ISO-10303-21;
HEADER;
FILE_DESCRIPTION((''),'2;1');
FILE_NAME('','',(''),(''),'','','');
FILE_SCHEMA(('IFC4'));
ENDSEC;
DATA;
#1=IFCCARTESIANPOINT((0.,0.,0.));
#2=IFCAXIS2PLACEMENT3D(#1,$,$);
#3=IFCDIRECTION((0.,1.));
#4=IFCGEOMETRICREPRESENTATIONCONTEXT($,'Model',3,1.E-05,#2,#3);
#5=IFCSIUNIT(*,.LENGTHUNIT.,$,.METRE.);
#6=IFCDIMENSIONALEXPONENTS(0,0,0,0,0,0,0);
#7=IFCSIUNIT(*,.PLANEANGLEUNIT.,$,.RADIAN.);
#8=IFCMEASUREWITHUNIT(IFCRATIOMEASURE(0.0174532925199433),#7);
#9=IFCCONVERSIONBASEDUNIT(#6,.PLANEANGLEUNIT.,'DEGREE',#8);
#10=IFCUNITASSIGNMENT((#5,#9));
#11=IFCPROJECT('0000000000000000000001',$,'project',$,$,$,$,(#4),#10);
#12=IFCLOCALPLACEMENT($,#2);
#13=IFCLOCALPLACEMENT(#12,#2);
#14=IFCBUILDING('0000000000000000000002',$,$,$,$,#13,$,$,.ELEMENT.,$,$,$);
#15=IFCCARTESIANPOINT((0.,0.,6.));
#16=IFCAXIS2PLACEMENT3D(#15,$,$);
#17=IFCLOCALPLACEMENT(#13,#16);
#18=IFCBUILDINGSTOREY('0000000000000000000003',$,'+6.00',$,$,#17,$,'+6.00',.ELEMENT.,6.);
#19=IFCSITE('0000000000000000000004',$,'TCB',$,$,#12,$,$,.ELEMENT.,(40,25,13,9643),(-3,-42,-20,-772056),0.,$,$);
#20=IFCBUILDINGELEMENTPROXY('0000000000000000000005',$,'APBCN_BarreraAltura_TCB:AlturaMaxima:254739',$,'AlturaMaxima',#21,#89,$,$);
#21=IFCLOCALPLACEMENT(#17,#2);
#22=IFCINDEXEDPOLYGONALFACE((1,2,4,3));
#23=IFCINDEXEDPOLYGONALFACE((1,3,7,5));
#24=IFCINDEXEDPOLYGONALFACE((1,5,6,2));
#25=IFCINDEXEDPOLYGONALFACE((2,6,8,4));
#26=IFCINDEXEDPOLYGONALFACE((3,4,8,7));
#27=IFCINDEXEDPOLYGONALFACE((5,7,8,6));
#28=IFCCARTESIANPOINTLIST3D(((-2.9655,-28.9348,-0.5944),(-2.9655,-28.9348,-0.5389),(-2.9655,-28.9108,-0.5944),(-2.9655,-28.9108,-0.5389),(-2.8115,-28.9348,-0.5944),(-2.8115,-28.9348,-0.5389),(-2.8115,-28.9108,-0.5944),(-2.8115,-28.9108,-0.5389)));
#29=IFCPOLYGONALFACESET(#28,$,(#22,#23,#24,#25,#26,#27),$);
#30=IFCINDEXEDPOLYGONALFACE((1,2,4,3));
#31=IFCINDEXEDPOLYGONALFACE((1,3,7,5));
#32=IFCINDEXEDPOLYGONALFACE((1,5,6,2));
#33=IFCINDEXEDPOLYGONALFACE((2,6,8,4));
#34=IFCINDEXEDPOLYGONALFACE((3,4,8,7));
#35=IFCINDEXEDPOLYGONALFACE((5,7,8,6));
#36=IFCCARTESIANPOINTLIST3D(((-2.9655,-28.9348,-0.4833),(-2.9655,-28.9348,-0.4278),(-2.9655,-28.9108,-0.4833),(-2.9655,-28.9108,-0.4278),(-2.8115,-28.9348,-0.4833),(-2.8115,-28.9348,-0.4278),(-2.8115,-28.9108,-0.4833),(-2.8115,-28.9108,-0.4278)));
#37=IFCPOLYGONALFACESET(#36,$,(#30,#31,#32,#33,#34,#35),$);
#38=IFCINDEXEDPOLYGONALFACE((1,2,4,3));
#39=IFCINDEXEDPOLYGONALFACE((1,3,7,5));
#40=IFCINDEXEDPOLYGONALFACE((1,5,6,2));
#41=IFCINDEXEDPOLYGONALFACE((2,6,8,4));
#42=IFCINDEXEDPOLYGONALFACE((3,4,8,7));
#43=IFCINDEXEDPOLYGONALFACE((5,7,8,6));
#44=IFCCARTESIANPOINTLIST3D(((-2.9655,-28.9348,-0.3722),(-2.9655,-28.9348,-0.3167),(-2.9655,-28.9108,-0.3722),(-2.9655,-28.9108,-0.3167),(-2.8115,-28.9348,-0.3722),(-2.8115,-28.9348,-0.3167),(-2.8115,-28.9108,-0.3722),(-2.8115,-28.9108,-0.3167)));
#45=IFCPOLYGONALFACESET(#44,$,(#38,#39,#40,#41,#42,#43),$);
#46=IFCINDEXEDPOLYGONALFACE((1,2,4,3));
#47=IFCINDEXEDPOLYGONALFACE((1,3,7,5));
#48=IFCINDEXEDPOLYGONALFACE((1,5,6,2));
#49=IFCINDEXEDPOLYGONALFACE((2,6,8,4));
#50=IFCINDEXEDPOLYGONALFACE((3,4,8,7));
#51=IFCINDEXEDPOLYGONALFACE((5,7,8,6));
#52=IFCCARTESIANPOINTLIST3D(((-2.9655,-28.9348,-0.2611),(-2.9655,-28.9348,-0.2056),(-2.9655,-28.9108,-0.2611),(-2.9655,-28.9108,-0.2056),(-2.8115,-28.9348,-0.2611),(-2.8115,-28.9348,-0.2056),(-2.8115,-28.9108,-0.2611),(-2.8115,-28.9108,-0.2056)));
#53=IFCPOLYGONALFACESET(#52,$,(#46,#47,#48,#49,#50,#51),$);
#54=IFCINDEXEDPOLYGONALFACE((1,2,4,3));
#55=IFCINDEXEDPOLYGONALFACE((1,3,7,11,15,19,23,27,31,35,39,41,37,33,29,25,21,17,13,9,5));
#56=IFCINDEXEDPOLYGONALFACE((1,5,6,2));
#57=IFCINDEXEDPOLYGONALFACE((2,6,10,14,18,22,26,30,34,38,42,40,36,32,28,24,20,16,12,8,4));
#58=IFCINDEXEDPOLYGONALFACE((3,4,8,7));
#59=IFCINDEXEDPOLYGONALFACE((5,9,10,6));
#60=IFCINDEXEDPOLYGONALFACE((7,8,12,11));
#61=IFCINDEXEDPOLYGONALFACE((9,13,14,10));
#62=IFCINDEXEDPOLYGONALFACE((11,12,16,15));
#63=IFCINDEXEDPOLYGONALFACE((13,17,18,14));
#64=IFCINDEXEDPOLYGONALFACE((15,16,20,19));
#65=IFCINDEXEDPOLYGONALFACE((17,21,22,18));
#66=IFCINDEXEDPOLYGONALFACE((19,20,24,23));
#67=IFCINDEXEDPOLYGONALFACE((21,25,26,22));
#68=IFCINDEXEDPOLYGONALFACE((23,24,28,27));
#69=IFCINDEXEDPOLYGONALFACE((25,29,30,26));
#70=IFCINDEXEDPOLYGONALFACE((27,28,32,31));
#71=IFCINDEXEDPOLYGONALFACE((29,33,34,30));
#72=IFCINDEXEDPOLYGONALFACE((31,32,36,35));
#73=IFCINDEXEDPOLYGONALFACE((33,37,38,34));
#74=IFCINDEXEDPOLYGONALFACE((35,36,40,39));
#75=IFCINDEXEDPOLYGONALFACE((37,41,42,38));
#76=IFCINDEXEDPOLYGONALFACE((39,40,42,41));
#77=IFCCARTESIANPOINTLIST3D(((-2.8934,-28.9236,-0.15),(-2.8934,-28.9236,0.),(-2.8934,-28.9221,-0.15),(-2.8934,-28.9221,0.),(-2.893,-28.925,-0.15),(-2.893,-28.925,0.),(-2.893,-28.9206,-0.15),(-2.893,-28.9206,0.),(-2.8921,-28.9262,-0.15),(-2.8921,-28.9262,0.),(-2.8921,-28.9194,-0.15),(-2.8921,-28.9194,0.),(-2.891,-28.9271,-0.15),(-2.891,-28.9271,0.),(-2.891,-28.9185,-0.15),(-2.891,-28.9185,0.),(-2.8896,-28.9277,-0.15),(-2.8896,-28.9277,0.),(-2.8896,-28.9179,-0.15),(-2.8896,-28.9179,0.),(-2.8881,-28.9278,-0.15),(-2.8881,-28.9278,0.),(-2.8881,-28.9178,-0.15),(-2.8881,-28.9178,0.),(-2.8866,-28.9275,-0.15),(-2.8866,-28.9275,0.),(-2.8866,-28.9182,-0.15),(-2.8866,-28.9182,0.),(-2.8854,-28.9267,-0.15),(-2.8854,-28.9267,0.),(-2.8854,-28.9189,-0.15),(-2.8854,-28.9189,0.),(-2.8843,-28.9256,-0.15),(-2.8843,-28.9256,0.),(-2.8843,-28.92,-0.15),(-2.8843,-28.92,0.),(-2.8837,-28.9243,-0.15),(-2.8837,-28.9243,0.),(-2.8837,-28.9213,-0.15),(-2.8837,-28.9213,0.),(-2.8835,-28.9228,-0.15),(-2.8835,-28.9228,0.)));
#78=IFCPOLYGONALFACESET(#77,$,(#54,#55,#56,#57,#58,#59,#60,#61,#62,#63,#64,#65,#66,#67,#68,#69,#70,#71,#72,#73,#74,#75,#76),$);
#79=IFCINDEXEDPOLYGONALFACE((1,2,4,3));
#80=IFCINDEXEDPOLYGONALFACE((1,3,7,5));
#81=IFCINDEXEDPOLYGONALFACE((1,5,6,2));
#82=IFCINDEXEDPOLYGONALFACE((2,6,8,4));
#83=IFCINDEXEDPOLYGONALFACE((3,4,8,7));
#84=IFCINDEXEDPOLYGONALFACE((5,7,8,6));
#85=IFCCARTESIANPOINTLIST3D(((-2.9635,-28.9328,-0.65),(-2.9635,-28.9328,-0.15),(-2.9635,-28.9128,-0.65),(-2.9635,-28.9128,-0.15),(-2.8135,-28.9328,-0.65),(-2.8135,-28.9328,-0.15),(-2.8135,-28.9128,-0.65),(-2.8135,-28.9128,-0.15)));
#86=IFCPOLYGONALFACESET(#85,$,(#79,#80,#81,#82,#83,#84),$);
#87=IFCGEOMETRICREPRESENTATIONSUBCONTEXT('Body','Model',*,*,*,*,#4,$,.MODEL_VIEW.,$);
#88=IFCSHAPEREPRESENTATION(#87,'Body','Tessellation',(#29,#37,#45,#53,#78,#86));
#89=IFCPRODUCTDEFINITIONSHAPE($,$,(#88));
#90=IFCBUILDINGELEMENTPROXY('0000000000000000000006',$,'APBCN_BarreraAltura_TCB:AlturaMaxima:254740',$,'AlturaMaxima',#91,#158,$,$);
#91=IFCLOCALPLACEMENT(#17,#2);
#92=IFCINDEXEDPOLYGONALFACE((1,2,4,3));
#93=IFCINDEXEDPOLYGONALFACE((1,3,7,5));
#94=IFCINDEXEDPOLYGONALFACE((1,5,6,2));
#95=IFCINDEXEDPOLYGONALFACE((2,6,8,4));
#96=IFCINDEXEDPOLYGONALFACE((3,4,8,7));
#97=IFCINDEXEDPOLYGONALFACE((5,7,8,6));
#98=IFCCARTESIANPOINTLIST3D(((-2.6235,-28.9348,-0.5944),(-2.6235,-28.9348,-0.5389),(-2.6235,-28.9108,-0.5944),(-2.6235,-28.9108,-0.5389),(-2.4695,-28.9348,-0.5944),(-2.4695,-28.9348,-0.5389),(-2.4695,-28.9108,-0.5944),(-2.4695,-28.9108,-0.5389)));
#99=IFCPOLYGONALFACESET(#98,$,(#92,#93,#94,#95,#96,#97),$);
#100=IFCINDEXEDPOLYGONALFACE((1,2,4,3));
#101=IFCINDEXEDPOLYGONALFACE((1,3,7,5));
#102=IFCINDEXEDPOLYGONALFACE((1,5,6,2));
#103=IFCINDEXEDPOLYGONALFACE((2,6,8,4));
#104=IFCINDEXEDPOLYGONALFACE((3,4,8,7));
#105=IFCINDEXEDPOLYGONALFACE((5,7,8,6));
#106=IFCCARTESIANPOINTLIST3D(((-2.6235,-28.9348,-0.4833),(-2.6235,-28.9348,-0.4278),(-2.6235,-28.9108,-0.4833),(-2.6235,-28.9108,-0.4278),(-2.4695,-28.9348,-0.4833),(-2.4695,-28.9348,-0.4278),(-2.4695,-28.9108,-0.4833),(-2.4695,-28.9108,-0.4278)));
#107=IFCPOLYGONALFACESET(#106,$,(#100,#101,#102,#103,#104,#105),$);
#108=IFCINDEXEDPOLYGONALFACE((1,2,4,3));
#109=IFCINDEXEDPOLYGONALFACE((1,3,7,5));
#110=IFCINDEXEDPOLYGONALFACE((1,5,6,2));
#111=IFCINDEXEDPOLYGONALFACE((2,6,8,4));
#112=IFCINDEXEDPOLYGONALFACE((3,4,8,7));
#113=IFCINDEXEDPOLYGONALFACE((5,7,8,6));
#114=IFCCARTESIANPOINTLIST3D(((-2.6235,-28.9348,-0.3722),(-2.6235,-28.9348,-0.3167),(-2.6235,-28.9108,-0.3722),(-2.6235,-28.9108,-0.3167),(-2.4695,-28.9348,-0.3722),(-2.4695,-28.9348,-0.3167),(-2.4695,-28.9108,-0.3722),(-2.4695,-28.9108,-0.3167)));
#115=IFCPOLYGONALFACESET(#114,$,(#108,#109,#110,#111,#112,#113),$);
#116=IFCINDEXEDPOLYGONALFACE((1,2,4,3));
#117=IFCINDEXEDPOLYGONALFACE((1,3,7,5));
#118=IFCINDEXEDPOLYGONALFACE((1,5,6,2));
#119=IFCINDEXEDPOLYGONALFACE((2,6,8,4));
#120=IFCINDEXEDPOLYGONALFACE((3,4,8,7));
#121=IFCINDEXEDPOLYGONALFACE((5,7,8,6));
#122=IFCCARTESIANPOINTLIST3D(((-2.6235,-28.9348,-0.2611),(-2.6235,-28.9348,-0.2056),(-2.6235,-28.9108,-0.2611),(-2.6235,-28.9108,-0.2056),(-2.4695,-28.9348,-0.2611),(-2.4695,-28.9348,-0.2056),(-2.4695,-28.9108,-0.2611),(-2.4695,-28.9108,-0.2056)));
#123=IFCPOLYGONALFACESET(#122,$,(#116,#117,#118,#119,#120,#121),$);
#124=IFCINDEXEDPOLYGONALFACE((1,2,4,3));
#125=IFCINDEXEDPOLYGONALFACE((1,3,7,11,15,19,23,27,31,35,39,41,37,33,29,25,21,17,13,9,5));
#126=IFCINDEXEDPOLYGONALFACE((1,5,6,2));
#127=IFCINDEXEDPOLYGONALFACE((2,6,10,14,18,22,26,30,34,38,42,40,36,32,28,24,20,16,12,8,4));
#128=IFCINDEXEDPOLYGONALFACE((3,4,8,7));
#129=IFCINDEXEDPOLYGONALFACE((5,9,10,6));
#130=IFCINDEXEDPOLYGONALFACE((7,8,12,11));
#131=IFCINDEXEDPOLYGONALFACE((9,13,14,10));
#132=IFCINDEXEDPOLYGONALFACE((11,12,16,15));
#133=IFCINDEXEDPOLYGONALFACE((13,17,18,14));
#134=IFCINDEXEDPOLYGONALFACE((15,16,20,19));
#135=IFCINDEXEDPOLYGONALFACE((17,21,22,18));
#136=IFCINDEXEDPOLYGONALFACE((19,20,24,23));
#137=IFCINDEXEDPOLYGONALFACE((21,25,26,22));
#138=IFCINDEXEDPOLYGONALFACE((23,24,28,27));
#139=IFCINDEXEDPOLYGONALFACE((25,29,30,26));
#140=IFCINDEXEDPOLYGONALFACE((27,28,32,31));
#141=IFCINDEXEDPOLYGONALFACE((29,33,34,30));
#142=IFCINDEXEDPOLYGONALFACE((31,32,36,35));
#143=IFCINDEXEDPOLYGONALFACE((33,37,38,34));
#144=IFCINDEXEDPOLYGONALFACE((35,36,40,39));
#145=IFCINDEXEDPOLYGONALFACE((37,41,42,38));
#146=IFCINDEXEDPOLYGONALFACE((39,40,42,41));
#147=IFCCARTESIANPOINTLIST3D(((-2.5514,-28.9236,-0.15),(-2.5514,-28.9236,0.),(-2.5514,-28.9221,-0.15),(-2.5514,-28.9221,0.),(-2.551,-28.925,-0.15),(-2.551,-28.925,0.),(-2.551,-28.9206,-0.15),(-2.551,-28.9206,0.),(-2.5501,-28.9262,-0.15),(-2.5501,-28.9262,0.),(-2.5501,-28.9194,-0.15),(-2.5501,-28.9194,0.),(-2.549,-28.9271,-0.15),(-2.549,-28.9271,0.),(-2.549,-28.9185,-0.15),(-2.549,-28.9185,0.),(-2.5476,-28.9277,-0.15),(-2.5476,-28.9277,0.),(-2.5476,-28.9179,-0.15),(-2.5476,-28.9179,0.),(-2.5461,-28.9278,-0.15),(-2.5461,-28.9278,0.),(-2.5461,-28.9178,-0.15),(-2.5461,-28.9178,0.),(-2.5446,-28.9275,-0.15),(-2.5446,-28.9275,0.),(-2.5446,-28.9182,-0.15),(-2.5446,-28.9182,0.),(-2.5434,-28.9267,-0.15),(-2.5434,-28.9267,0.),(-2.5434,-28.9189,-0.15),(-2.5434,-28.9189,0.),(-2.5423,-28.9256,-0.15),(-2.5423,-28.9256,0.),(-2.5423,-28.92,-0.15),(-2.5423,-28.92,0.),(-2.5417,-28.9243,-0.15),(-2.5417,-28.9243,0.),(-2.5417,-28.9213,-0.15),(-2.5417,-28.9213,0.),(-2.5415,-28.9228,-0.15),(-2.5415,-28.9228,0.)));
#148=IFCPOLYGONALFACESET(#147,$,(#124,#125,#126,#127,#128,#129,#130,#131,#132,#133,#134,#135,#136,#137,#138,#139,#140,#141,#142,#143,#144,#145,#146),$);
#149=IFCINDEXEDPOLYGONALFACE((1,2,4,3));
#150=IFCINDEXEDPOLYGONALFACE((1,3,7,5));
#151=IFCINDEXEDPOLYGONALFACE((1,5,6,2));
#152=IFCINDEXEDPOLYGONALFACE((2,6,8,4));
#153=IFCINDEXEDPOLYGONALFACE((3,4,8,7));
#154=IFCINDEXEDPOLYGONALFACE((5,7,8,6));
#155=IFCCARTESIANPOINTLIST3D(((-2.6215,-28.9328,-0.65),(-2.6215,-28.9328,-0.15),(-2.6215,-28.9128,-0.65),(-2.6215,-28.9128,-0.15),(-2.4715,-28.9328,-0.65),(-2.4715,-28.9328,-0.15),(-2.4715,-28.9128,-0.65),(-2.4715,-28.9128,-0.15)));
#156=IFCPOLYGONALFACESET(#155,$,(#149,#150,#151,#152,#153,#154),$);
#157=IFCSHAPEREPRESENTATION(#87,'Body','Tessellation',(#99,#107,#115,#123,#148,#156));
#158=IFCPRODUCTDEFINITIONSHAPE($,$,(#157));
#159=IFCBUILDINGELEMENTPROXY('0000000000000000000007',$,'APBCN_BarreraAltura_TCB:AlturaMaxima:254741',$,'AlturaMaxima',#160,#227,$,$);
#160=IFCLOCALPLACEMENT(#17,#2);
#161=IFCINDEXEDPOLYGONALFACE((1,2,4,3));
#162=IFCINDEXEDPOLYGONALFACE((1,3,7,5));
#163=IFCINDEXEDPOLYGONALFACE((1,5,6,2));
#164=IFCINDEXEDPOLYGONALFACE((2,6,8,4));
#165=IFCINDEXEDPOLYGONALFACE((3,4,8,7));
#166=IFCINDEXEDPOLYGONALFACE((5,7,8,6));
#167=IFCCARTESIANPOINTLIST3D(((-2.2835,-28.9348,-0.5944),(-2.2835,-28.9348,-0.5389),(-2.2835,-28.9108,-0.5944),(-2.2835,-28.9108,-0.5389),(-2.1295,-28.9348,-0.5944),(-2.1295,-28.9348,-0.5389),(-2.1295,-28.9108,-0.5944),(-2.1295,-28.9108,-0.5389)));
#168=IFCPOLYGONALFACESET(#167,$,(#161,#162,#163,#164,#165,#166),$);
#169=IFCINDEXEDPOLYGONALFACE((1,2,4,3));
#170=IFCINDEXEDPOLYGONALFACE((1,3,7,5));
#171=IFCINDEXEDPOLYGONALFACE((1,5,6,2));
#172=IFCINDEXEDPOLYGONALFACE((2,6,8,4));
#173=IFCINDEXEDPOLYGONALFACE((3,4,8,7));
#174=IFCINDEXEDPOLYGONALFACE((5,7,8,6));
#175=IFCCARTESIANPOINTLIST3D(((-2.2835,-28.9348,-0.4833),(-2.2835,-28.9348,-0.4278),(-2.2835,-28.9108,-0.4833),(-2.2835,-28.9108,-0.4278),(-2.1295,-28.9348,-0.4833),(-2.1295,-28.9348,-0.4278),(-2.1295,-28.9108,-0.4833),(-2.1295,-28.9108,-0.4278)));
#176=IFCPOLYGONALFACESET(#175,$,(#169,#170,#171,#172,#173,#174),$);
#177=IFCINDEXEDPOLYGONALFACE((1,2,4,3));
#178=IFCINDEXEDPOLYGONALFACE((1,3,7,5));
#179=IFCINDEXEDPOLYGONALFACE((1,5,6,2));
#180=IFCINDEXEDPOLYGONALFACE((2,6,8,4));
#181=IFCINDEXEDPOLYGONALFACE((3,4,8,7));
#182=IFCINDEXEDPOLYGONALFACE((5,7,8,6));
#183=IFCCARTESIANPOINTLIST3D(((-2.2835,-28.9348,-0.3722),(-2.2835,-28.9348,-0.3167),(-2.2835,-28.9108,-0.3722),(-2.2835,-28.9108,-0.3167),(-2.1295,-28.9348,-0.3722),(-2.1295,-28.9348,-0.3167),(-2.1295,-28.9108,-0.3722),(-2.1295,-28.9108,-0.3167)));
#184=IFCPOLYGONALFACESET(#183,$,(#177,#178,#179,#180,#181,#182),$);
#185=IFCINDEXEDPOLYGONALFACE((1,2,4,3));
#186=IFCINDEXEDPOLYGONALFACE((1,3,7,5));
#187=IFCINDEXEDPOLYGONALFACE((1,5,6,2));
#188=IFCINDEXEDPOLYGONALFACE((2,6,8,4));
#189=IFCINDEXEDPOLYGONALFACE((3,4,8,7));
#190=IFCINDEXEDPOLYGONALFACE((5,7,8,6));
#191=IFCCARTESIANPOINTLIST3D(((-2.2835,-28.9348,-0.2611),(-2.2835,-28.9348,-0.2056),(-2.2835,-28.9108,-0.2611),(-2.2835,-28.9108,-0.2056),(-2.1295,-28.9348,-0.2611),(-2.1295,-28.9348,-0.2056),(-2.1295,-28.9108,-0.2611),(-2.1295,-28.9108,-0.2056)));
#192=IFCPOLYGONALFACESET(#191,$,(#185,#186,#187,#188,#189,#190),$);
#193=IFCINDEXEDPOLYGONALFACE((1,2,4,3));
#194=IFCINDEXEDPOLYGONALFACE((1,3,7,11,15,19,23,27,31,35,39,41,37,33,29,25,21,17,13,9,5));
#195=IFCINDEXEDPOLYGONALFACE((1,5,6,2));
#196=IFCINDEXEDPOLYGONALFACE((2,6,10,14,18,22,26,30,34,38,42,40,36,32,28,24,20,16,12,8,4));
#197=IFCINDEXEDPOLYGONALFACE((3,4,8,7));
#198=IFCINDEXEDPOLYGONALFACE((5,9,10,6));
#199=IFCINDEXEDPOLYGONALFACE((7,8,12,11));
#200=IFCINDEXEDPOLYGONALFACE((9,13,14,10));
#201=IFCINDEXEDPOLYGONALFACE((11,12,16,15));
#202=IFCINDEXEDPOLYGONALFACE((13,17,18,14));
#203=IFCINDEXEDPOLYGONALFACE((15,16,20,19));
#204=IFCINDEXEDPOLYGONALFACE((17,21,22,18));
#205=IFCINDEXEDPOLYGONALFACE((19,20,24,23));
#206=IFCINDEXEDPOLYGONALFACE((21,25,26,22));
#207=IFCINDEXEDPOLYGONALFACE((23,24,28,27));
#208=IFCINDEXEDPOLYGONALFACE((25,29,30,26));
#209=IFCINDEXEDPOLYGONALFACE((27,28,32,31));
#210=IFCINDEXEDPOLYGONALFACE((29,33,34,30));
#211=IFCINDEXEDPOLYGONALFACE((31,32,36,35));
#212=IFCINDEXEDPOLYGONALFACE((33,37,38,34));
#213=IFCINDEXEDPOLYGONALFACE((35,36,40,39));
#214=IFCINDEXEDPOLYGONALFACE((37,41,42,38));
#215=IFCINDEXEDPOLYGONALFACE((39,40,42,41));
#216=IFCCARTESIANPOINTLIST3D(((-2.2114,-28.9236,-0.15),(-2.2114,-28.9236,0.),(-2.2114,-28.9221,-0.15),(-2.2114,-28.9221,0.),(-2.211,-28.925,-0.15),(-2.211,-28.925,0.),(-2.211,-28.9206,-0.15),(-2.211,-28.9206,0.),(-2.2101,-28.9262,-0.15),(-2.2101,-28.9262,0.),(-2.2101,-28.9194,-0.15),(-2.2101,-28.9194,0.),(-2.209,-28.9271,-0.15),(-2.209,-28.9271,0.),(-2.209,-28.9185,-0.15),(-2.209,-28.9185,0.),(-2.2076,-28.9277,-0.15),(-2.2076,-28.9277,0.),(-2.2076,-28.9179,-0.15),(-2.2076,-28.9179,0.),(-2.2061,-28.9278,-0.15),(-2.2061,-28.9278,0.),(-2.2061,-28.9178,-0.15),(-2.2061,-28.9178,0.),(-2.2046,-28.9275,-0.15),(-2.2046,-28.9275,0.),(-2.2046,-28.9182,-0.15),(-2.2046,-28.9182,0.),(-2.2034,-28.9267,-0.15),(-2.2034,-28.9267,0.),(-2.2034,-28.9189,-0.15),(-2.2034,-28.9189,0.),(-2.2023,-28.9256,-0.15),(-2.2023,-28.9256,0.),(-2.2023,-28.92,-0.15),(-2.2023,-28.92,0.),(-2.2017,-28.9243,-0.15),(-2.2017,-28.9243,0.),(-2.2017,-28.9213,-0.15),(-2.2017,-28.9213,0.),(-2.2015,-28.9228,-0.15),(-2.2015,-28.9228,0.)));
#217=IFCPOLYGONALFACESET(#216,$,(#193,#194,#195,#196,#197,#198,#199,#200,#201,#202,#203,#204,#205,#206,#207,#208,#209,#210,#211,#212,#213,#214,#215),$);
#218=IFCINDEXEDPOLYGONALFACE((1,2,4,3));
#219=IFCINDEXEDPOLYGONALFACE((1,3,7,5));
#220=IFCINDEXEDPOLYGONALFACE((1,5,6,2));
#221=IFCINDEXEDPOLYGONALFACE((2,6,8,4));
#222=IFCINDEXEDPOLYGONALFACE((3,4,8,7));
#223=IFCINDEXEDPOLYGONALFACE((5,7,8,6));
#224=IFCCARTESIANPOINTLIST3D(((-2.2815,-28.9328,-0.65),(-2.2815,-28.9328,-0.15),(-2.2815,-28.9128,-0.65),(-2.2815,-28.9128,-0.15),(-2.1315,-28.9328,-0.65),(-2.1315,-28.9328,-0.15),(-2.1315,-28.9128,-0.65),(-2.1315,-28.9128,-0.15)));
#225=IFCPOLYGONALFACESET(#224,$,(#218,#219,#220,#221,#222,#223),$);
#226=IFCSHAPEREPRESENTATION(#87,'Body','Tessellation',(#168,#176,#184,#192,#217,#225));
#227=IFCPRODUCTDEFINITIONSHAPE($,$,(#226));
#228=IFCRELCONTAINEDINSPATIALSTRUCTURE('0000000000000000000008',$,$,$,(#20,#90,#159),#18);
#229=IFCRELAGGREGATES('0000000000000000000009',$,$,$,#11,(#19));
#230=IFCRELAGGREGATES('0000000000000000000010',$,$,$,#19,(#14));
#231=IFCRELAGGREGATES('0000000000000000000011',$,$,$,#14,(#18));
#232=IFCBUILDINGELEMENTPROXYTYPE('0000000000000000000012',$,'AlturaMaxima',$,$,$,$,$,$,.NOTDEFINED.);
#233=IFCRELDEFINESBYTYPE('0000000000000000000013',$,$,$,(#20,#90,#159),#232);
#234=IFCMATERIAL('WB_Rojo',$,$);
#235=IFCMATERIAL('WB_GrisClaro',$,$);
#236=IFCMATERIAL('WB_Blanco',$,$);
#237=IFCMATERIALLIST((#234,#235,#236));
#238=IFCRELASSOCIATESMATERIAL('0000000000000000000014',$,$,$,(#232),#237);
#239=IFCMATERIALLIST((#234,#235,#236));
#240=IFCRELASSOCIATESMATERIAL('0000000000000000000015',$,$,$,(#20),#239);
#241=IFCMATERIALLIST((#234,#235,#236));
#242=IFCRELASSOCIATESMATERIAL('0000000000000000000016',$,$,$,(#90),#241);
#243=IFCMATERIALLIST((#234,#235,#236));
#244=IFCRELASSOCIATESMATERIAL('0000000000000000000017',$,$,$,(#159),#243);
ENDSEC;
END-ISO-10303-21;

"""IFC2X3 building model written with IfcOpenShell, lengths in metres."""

from ifc_helpers import new_model, entity, si_unit, converted_unit, direction, frame, frame_2d, origin, origin_2d_with_axis, place, context, subcontext, project, spatial, rectangle, circle, extrude, source, transform, mapped, material, material_list, type_object, type_shapes, element, save


model = new_model("IFC2X3")

# Units and contexts
model_context = context("Model", 3, precision=1e-05, world=origin(), true_north=direction((0.0, 1.0)))
body_context = subcontext(model_context, "Body", "Model", "MODEL_VIEW")
ifc_project = project(units=[si_unit("LENGTHUNIT", "METRE"), converted_unit("PLANEANGLEUNIT", "DEGREE", entity("IfcRatioMeasure", 0.0174532925199433), si_unit("PLANEANGLEUNIT", "RADIAN"), dimensions=[0, 0, 0, 0, 0, 0, 0])], contexts=[model_context])

# Site, building, storey
site_placement = place(None, origin())
site = spatial("IfcSite", under=ifc_project, at=site_placement, Name="TCB", CompositionType="ELEMENT", RefLatitude=(40, 25, 13, 9643), RefLongitude=(-3, -42, -20, -772056), RefElevation=0.0)
building_placement = place(site_placement, origin())
building = spatial("IfcBuilding", under=site, at=building_placement, CompositionType="ELEMENT")
storey_placement = place(building_placement, frame((0.0, 0.0, 6.0)))
storey = spatial("IfcBuildingStorey", under=building, at=storey_placement, Name="+6.00", LongName="+6.00", CompositionType="ELEMENT", Elevation=6.0)

# Building element proxies
ifc_material_1 = material(Name="WB_Rojo")
ifc_material_2 = material(Name="WB_GrisClaro")
ifc_material_3 = material(Name="WB_Blanco")
ifc_material_list_1 = material_list([ifc_material_1, ifc_material_2, ifc_material_3])
building_element_proxy_type = type_object("IfcBuildingElementProxyType", Name="AlturaMaxima", PredefinedType="NOTDEFINED", material=ifc_material_list_1)
shared_shape = source(origin(), body_context, "Body", "SweptSolid", [
    extrude(rectangle(XDim=0.154, YDim=0.024, at=frame_2d((0.0, 0.0), x_axis=(1.0, 0.0))), frame((0.0, 0.0, -0.5944), z_axis=(0.0, 0.0, 1.0), x_axis=(-1.0, 0.0, 0.0)), (0.0, 0.0, 1.0), 0.0556),
    extrude(rectangle(XDim=0.154, YDim=0.024, at=frame_2d((0.0, 0.0), x_axis=(1.0, 0.0))), frame((0.0, 0.0, -0.4833), z_axis=(0.0, 0.0, 1.0), x_axis=(-1.0, 0.0, 0.0)), (0.0, 0.0, 1.0), 0.0556),
    extrude(rectangle(XDim=0.154, YDim=0.024, at=frame_2d((0.0, 0.0), x_axis=(1.0, 0.0))), frame((0.0, 0.0, -0.3722), z_axis=(0.0, 0.0, 1.0), x_axis=(-1.0, 0.0, 0.0)), (0.0, 0.0, 1.0), 0.0556),
    extrude(rectangle(XDim=0.154, YDim=0.024, at=frame_2d((0.0, 0.0), x_axis=(1.0, 0.0))), frame((0.0, 0.0, -0.2611), z_axis=(0.0, 0.0, 1.0), x_axis=(-1.0, 0.0, 0.0)), (0.0, 0.0, 1.0), 0.0556),
    extrude(circle(Radius=0.005, at=frame_2d((0.0, 0.0), x_axis=(1.0, 0.0))), frame((0.0, 0.0, -0.15)), (0.0, 0.0, 1.0), 0.15),
    extrude(rectangle(XDim=0.02, YDim=0.15, at=origin_2d_with_axis()), frame((0.0, 0.0, -0.65), z_axis=(0.0, 0.0, 1.0), x_axis=(0.0, 1.0, 0.0)), (0.0, 0.0, 1.0), 0.5),
])
type_shapes(building_element_proxy_type, [shared_shape])
ifc_material_list_2 = material_list([ifc_material_1, ifc_material_2, ifc_material_3])
proxy_1_placement = place(storey_placement, frame((-2.8885, -28.9228, 0.0)))
element("IfcBuildingElementProxy", 1, at=proxy_1_placement, inside=storey, type_object=building_element_proxy_type, material=ifc_material_list_2, Name="APBCN_BarreraAltura_TCB:AlturaMaxima:254739", ObjectType="AlturaMaxima", context=body_context, shape_type="MappedRepresentation", body=[
    mapped(shared_shape, transform((0.0, 0.0, 0.0), scale=1.0)),
])
ifc_material_list_3 = material_list([ifc_material_1, ifc_material_2, ifc_material_3])
proxy_2_placement = place(storey_placement, frame((-2.5465, -28.9228, 0.0)))
element("IfcBuildingElementProxy", 2, at=proxy_2_placement, inside=storey, type_object=building_element_proxy_type, material=ifc_material_list_3, Name="APBCN_BarreraAltura_TCB:AlturaMaxima:254740", ObjectType="AlturaMaxima", context=body_context, shape_type="MappedRepresentation", body=[
    mapped(shared_shape, transform((0.0, 0.0, 0.0), scale=1.0)),
])
ifc_material_list_4 = material_list([ifc_material_1, ifc_material_2, ifc_material_3])
proxy_3_placement = place(storey_placement, frame((-2.2065, -28.9228, 0.0)))
element("IfcBuildingElementProxy", 3, at=proxy_3_placement, inside=storey, type_object=building_element_proxy_type, material=ifc_material_list_4, Name="APBCN_BarreraAltura_TCB:AlturaMaxima:254741", ObjectType="AlturaMaxima", context=body_context, shape_type="MappedRepresentation", body=[
    mapped(shared_shape, transform((0.0, 0.0, 0.0), scale=1.0)),
])

save(model, "model.ifc")
